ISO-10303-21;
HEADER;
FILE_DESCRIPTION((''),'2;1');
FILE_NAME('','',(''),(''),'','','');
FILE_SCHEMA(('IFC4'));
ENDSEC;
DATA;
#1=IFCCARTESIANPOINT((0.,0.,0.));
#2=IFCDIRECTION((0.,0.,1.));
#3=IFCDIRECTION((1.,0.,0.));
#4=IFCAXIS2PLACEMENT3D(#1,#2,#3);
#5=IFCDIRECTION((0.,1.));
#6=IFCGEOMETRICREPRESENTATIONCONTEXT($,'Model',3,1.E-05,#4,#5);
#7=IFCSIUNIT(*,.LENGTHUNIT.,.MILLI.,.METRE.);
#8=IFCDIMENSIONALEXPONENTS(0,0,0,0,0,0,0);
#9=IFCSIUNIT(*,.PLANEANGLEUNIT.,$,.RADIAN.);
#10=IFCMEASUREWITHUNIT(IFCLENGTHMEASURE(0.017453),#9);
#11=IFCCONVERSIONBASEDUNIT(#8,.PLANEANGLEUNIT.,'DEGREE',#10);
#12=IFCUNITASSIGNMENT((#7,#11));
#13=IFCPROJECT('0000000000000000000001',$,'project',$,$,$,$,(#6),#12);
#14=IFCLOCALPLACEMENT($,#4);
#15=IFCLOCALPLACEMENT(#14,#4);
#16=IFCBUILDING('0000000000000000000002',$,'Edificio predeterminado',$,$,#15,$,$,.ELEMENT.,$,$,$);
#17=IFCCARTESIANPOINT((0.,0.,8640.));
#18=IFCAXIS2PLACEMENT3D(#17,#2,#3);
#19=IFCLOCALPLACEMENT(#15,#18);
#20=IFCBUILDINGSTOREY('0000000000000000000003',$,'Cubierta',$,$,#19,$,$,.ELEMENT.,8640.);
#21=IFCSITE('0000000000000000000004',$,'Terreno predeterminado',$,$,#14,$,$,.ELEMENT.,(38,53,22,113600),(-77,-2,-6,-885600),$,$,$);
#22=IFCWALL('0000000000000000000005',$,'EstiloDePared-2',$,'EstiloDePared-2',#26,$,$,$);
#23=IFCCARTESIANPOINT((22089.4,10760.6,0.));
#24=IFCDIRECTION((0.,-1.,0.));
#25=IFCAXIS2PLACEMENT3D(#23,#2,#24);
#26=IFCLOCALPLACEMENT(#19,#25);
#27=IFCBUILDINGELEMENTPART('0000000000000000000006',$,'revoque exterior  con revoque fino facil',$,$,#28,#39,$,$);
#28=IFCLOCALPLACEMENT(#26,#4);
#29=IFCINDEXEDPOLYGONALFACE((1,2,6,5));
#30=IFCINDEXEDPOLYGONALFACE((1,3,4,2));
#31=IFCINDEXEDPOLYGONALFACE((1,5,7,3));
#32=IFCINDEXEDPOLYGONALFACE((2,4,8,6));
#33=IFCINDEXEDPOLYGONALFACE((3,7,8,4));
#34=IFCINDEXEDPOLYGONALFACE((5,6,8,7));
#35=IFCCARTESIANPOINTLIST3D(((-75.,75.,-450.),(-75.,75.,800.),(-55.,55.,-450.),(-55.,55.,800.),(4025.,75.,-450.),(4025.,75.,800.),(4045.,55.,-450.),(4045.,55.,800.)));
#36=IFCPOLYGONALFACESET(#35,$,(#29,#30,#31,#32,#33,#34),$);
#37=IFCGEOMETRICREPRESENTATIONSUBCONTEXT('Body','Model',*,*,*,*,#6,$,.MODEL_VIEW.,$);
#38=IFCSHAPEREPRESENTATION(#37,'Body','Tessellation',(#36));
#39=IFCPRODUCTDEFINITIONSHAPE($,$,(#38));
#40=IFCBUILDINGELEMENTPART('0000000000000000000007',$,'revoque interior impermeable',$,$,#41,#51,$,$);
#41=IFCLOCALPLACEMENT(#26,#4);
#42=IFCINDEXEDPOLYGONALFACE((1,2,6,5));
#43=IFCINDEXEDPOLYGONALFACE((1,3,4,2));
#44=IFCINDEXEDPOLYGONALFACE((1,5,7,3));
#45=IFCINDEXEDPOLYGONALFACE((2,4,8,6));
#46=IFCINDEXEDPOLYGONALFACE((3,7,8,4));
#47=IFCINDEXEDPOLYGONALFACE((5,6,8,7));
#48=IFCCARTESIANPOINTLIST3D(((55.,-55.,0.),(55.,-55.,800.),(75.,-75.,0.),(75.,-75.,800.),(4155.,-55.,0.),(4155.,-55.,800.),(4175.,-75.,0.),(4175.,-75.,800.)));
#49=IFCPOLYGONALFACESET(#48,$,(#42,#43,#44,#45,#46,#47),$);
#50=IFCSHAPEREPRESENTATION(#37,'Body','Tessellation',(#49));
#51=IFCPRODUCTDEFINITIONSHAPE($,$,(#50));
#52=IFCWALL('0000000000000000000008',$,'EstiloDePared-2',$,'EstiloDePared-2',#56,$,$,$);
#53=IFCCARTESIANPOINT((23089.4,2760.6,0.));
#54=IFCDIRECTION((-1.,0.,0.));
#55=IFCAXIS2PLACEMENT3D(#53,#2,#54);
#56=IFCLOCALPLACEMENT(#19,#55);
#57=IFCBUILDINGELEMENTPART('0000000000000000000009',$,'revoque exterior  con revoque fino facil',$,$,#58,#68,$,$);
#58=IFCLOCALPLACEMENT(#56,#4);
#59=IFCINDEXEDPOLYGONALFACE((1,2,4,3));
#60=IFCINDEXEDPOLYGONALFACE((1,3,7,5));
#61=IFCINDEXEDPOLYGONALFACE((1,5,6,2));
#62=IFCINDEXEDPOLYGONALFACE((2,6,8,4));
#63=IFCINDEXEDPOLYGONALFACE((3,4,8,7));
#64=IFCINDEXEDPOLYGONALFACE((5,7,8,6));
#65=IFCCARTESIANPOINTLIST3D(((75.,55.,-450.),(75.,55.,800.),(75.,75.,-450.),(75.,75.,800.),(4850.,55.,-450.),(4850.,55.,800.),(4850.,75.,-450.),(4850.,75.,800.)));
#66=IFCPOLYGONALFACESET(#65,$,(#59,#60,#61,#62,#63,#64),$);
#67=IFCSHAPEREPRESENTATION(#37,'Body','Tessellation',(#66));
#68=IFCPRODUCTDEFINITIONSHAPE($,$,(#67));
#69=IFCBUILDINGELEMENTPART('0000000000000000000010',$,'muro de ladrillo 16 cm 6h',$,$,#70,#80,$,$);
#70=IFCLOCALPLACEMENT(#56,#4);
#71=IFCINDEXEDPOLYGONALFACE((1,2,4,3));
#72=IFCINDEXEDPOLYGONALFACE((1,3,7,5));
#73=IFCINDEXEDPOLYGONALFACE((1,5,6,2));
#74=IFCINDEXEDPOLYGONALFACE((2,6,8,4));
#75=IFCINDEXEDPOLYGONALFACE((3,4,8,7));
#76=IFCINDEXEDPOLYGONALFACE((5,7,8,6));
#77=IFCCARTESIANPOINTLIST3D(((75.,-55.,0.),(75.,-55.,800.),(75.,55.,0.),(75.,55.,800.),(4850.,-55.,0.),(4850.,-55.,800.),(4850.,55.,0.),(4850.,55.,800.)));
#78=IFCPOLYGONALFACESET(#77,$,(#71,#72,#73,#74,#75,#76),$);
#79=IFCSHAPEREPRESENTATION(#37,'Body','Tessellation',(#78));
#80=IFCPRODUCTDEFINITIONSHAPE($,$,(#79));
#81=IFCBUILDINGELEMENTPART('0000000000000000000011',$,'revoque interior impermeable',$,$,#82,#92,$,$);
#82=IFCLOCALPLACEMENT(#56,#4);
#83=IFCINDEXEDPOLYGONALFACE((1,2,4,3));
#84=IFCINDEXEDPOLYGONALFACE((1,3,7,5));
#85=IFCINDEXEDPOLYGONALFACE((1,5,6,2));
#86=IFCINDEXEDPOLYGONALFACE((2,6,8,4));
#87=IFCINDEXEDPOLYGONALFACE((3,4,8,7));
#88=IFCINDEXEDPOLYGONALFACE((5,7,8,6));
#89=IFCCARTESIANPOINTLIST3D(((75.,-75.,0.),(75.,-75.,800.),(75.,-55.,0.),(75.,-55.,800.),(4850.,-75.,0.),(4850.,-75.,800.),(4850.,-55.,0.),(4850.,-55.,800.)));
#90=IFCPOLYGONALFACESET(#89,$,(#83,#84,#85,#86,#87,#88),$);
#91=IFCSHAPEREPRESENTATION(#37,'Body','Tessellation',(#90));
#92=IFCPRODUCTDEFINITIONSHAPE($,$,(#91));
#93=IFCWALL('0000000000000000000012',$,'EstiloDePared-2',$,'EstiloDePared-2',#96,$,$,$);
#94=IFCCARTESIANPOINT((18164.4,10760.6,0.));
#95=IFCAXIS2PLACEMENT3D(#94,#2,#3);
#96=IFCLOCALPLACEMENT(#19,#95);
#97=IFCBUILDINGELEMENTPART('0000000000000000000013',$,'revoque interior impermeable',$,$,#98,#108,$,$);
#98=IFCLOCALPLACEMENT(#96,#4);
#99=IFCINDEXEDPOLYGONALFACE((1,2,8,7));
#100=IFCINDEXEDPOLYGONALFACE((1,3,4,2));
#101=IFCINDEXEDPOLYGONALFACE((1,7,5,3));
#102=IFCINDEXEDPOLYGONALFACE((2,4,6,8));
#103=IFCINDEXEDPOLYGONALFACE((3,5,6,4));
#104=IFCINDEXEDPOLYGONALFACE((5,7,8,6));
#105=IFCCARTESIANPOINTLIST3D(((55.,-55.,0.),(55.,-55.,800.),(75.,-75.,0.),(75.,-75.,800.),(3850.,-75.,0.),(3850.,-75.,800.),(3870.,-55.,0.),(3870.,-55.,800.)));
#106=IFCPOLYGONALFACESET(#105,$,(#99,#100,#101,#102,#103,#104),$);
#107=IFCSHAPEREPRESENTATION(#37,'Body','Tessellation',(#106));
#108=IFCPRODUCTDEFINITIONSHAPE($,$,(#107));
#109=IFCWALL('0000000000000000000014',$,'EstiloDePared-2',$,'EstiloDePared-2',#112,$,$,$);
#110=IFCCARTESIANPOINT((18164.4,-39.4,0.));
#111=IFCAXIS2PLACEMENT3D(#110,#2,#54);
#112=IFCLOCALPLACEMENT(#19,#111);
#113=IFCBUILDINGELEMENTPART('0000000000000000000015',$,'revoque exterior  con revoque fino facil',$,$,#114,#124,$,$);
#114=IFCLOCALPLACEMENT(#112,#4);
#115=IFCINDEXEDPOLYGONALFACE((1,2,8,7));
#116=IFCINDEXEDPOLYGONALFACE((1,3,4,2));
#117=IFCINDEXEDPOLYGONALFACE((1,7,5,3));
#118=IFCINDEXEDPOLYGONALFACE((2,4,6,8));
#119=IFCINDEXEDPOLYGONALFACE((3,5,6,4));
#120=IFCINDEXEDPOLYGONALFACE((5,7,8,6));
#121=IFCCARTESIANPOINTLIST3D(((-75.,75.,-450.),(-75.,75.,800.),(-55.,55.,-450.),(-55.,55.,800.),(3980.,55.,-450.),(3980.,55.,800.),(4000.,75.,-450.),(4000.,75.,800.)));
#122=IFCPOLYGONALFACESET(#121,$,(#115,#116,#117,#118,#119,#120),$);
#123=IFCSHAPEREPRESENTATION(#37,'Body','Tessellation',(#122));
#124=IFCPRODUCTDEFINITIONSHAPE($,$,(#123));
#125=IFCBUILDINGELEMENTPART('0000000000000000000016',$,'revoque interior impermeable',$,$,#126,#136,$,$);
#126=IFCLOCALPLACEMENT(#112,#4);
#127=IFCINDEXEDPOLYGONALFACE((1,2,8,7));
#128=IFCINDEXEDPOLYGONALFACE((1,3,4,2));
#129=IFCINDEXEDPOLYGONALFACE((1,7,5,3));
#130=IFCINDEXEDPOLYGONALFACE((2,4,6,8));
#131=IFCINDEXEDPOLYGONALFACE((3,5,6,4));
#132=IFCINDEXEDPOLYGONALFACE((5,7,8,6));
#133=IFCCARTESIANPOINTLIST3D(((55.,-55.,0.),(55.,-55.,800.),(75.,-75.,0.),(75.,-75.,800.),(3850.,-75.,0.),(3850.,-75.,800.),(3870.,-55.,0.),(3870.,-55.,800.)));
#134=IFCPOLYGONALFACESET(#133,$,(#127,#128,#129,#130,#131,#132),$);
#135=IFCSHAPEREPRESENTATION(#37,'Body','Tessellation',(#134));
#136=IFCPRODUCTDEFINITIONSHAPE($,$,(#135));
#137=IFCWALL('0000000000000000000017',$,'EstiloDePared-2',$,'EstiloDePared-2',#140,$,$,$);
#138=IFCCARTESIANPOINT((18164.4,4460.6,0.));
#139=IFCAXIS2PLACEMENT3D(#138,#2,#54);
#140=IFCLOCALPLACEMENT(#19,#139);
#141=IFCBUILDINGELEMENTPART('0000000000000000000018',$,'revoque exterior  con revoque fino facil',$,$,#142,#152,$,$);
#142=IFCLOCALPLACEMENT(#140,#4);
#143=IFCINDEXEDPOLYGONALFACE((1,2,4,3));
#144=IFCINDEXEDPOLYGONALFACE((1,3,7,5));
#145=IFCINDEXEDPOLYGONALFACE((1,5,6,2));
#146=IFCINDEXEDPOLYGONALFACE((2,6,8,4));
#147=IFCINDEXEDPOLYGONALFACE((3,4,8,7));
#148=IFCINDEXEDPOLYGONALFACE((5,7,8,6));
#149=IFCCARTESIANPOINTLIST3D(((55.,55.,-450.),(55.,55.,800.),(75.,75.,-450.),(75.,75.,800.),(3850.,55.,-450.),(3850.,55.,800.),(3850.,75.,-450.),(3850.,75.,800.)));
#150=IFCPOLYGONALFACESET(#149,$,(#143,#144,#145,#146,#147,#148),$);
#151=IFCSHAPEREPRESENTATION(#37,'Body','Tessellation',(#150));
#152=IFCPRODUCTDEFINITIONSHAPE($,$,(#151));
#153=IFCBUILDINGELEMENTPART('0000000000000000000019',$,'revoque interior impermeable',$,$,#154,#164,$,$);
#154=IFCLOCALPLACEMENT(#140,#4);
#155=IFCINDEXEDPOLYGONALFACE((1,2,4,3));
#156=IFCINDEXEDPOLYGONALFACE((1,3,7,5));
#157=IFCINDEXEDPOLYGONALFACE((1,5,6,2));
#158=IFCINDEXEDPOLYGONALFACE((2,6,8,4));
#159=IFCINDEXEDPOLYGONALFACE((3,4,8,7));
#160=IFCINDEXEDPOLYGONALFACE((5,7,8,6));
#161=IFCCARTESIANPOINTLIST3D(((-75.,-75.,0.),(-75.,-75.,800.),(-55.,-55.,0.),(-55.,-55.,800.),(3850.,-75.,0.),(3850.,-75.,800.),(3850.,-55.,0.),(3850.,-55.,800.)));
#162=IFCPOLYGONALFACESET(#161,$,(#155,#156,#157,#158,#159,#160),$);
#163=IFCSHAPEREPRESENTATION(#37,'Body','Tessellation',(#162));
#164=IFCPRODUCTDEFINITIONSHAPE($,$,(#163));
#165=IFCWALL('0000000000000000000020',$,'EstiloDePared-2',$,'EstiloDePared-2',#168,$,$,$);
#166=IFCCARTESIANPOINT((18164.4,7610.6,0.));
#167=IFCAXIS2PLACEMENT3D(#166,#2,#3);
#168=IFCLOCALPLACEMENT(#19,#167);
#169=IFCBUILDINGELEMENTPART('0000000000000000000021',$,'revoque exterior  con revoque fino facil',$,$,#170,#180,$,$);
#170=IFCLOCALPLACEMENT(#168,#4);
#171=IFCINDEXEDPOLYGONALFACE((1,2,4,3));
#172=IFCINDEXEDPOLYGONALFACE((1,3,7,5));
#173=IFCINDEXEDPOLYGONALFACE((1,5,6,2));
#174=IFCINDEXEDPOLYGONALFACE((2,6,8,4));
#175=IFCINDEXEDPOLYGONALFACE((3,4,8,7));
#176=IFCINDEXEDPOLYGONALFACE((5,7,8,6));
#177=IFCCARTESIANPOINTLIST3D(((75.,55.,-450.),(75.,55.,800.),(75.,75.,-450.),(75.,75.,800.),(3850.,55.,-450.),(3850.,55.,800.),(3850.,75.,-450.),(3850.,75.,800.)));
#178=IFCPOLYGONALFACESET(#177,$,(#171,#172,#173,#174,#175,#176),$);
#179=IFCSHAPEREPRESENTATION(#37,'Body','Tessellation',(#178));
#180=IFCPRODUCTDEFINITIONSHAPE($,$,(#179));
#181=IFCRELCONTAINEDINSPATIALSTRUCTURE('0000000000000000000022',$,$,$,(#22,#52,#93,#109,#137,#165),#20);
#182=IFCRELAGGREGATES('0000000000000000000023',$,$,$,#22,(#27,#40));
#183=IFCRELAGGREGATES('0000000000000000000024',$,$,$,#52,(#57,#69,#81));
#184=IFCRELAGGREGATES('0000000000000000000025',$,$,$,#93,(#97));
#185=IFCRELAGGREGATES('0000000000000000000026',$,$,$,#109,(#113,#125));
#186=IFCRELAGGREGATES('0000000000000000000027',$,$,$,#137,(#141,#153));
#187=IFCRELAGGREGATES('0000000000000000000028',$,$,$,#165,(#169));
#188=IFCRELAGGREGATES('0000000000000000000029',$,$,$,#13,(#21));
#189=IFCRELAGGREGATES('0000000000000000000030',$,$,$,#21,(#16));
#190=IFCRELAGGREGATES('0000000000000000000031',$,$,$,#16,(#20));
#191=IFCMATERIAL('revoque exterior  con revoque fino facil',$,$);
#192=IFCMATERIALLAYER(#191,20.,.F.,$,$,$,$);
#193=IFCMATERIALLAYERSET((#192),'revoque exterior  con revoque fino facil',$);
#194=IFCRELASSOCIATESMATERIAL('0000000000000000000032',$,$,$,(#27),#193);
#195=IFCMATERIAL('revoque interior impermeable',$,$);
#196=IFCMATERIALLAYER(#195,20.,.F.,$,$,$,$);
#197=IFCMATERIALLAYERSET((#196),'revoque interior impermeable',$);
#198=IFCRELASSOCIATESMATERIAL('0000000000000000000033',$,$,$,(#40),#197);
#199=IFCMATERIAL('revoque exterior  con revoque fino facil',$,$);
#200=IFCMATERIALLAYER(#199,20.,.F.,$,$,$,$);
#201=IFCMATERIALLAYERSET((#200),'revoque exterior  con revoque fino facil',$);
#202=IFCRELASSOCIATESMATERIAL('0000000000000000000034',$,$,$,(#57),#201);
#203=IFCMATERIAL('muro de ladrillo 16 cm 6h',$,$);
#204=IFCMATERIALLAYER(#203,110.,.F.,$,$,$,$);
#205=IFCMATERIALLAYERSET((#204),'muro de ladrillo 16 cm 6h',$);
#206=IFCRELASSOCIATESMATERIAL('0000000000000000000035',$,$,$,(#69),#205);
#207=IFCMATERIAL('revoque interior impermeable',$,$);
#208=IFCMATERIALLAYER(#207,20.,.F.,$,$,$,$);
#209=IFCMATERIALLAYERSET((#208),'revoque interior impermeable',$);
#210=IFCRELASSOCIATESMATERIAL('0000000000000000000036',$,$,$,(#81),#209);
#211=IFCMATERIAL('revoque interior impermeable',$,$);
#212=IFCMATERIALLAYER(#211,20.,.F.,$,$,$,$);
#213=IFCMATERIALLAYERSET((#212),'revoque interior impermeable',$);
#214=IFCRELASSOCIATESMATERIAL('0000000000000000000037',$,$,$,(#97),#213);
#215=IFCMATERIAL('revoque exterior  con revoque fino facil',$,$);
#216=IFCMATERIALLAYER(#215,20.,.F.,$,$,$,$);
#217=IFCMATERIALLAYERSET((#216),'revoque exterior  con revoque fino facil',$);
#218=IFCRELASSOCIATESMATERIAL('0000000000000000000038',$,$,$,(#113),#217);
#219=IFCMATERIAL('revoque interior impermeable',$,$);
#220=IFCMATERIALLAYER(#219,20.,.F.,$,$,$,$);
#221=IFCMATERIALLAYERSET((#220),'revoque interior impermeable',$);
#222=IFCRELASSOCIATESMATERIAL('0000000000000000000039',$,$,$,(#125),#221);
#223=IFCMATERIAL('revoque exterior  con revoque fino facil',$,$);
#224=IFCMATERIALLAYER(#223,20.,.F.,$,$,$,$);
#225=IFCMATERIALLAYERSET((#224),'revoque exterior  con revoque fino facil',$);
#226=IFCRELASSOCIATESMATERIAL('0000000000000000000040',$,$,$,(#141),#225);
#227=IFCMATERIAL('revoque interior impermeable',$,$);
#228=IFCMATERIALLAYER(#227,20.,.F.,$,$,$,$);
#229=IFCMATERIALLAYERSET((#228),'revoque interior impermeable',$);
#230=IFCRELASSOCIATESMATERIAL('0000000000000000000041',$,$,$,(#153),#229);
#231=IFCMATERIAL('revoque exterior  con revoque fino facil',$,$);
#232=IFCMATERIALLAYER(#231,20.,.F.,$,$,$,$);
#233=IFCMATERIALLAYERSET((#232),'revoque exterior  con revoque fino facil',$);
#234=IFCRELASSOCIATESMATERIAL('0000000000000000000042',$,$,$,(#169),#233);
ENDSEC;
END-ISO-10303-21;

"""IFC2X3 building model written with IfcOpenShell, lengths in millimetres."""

from ifc_helpers import new_model, entity, si_unit, converted_unit, direction, frame, origin_with_axes, place, context, subcontext, project, spatial, polyline, outline, extrude, material, layer, layer_set, layer_usage, element, aggregate, save


model = new_model("IFC2X3")

# Units and contexts
model_context = context("Model", 3, precision=1e-05, world=origin_with_axes(), true_north=direction((0.0, 1.0)))
body_context = subcontext(model_context, "Body", "Model", "MODEL_VIEW")
ifc_project = project(units=[si_unit("LENGTHUNIT", "METRE", prefix="MILLI"), converted_unit("PLANEANGLEUNIT", "DEGREE", entity("IfcLengthMeasure", 0.017453), si_unit("PLANEANGLEUNIT", "RADIAN"), dimensions=[0, 0, 0, 0, 0, 0, 0])], contexts=[model_context])

# Site, building, storey
site_placement = place(None, origin_with_axes())
site = spatial("IfcSite", under=ifc_project, at=site_placement, Name="Terreno predeterminado", CompositionType="ELEMENT", RefLatitude=(38, 53, 22, 113600), RefLongitude=(-77, -2, -6, -885600))
building_placement = place(site_placement, origin_with_axes())
building = spatial("IfcBuilding", under=site, at=building_placement, Name="Edificio predeterminado", CompositionType="ELEMENT")
storey_placement = place(building_placement, frame((0.0, 0.0, 8640.0), z_axis=(0.0, 0.0, 1.0), x_axis=(1.0, 0.0, 0.0)))
storey = spatial("IfcBuildingStorey", under=building, at=storey_placement, Name="Cubierta", CompositionType="ELEMENT", Elevation=8640.0)

# Walls, building element parts
wall_1_placement = place(storey_placement, frame((22089.4, 10760.6, 0.0), z_axis=(0.0, 0.0, 1.0), x_axis=(0.0, -1.0, 0.0)))
wall_1 = element("IfcWall", 1, at=wall_1_placement, inside=storey, Name="EstiloDePared-2", ObjectType="EstiloDePared-2")
ifc_material_1 = material(Name="revoque exterior  con revoque fino facil")
ifc_layer_1 = layer(ifc_material_1, 20.0, ventilated=False)
ifc_layer_set_1 = layer_set([ifc_layer_1], Name="revoque exterior  con revoque fino facil")
ifc_layer_usage_1 = layer_usage(ifc_layer_set_1, "AXIS2", "NEGATIVE", -75.0)
building_element_part_1_placement = place(wall_1_placement, origin_with_axes())
building_element_part_1 = element("IfcBuildingElementPart", 2, at=building_element_part_1_placement, material=ifc_layer_usage_1, Name="revoque exterior  con revoque fino facil", context=body_context, shape_type="SweptSolid", body=[
    extrude(outline(polyline([(4025.0, 75.0), (4045.0, 55.0), (-55.0, 55.0), (-75.0, 75.0), (4025.0, 75.0)])), frame((0.0, 0.0, -450.0), z_axis=(0.0, 0.0, 1.0), x_axis=(1.0, 0.0, 0.0)), (0.0, 0.0, 1.0), 1250.0),
])
ifc_material_2 = material(Name="revoque interior impermeable")
ifc_layer_2 = layer(ifc_material_2, 20.0, ventilated=False)
ifc_layer_set_2 = layer_set([ifc_layer_2], Name="revoque interior impermeable")
ifc_layer_usage_2 = layer_usage(ifc_layer_set_2, "AXIS2", "NEGATIVE", 55.0)
building_element_part_2_placement = place(wall_1_placement, origin_with_axes())
building_element_part_2 = element("IfcBuildingElementPart", 3, at=building_element_part_2_placement, material=ifc_layer_usage_2, Name="revoque interior impermeable", context=body_context, shape_type="SweptSolid", body=[
    extrude(outline(polyline([(4155.0, -55.0), (4175.0, -75.0), (75.0, -75.0), (55.0, -55.0), (4155.0, -55.0)])), origin_with_axes(), (0.0, 0.0, 1.0), 800.0),
])
aggregate(wall_1, [building_element_part_1, building_element_part_2])
wall_2_placement = place(storey_placement, frame((23089.4, 2760.6, 0.0), z_axis=(0.0, 0.0, 1.0), x_axis=(-1.0, 0.0, 0.0)))
wall_2 = element("IfcWall", 4, at=wall_2_placement, inside=storey, Name="EstiloDePared-2", ObjectType="EstiloDePared-2")
ifc_material_3 = material(Name="revoque exterior  con revoque fino facil")
ifc_layer_3 = layer(ifc_material_3, 20.0, ventilated=False)
ifc_layer_set_3 = layer_set([ifc_layer_3], Name="revoque exterior  con revoque fino facil")
ifc_layer_usage_3 = layer_usage(ifc_layer_set_3, "AXIS2", "NEGATIVE", -75.0)
building_element_part_3_placement = place(wall_2_placement, origin_with_axes())
building_element_part_3 = element("IfcBuildingElementPart", 5, at=building_element_part_3_placement, material=ifc_layer_usage_3, Name="revoque exterior  con revoque fino facil", context=body_context, shape_type="SweptSolid", body=[
    extrude(outline(polyline([(4850.0, 75.0), (4850.0, 55.0), (75.0, 55.0), (75.0, 75.0), (4850.0, 75.0)])), frame((0.0, 0.0, -450.0), z_axis=(0.0, 0.0, 1.0), x_axis=(1.0, 0.0, 0.0)), (0.0, 0.0, 1.0), 1250.0),
])
ifc_material_4 = material(Name="muro de ladrillo 16 cm 6h")
ifc_layer_4 = layer(ifc_material_4, 110.0, ventilated=False)
ifc_layer_set_4 = layer_set([ifc_layer_4], Name="muro de ladrillo 16 cm 6h")
ifc_layer_usage_4 = layer_usage(ifc_layer_set_4, "AXIS2", "NEGATIVE", -55.0)
building_element_part_4_placement = place(wall_2_placement, origin_with_axes())
building_element_part_4 = element("IfcBuildingElementPart", 6, at=building_element_part_4_placement, material=ifc_layer_usage_4, Name="muro de ladrillo 16 cm 6h", context=body_context, shape_type="SweptSolid", body=[
    extrude(outline(polyline([(4850.0, 55.0), (4850.0, -55.0), (75.0, -55.0), (75.0, 55.0), (4850.0, 55.0)])), origin_with_axes(), (0.0, 0.0, 1.0), 800.0),
])
ifc_material_5 = material(Name="revoque interior impermeable")
ifc_layer_5 = layer(ifc_material_5, 20.0, ventilated=False)
ifc_layer_set_5 = layer_set([ifc_layer_5], Name="revoque interior impermeable")
ifc_layer_usage_5 = layer_usage(ifc_layer_set_5, "AXIS2", "NEGATIVE", 55.0)
building_element_part_5_placement = place(wall_2_placement, origin_with_axes())
building_element_part_5 = element("IfcBuildingElementPart", 7, at=building_element_part_5_placement, material=ifc_layer_usage_5, Name="revoque interior impermeable", context=body_context, shape_type="SweptSolid", body=[
    extrude(outline(polyline([(4850.0, -55.0), (4850.0, -75.0), (75.0, -75.0), (75.0, -55.0), (4850.0, -55.0)])), origin_with_axes(), (0.0, 0.0, 1.0), 800.0),
])
aggregate(wall_2, [building_element_part_3, building_element_part_4, building_element_part_5])

# Wall, building element part
wall_3_placement = place(storey_placement, frame((18164.4, 10760.6, 0.0), z_axis=(0.0, 0.0, 1.0), x_axis=(1.0, 0.0, 0.0)))
wall_3 = element("IfcWall", 8, at=wall_3_placement, inside=storey, Name="EstiloDePared-2", ObjectType="EstiloDePared-2")
ifc_material_6 = material(Name="revoque interior impermeable")
ifc_layer_6 = layer(ifc_material_6, 20.0, ventilated=False)
ifc_layer_set_6 = layer_set([ifc_layer_6], Name="revoque interior impermeable")
ifc_layer_usage_6 = layer_usage(ifc_layer_set_6, "AXIS2", "NEGATIVE", 55.0)
building_element_part_6_placement = place(wall_3_placement, origin_with_axes())
building_element_part_6 = element("IfcBuildingElementPart", 9, at=building_element_part_6_placement, material=ifc_layer_usage_6, Name="revoque interior impermeable", context=body_context, shape_type="SweptSolid", body=[
    extrude(outline(polyline([(3870.0, -55.0), (3850.0, -75.0), (75.0, -75.0), (55.0, -55.0), (3870.0, -55.0)])), origin_with_axes(), (0.0, 0.0, 1.0), 800.0),
])
aggregate(wall_3, [building_element_part_6])

# Walls, building element parts
wall_4_placement = place(storey_placement, frame((18164.4, -39.4, 0.0), z_axis=(0.0, 0.0, 1.0), x_axis=(-1.0, 0.0, 0.0)))
wall_4 = element("IfcWall", 10, at=wall_4_placement, inside=storey, Name="EstiloDePared-2", ObjectType="EstiloDePared-2")
ifc_material_7 = material(Name="revoque exterior  con revoque fino facil")
ifc_layer_7 = layer(ifc_material_7, 20.0, ventilated=False)
ifc_layer_set_7 = layer_set([ifc_layer_7], Name="revoque exterior  con revoque fino facil")
ifc_layer_usage_7 = layer_usage(ifc_layer_set_7, "AXIS2", "NEGATIVE", -75.0)
building_element_part_7_placement = place(wall_4_placement, origin_with_axes())
building_element_part_7 = element("IfcBuildingElementPart", 11, at=building_element_part_7_placement, material=ifc_layer_usage_7, Name="revoque exterior  con revoque fino facil", context=body_context, shape_type="SweptSolid", body=[
    extrude(outline(polyline([(4000.0, 75.0), (3980.0, 55.0), (-55.0, 55.0), (-75.0, 75.0), (4000.0, 75.0)])), frame((0.0, 0.0, -450.0), z_axis=(0.0, 0.0, 1.0), x_axis=(1.0, 0.0, 0.0)), (0.0, 0.0, 1.0), 1250.0),
])
ifc_material_8 = material(Name="revoque interior impermeable")
ifc_layer_8 = layer(ifc_material_8, 20.0, ventilated=False)
ifc_layer_set_8 = layer_set([ifc_layer_8], Name="revoque interior impermeable")
ifc_layer_usage_8 = layer_usage(ifc_layer_set_8, "AXIS2", "NEGATIVE", 55.0)
building_element_part_8_placement = place(wall_4_placement, origin_with_axes())
building_element_part_8 = element("IfcBuildingElementPart", 12, at=building_element_part_8_placement, material=ifc_layer_usage_8, Name="revoque interior impermeable", context=body_context, shape_type="SweptSolid", body=[
    extrude(outline(polyline([(3870.0, -55.0), (3850.0, -75.0), (75.0, -75.0), (55.0, -55.0), (3870.0, -55.0)])), origin_with_axes(), (0.0, 0.0, 1.0), 800.0),
])
aggregate(wall_4, [building_element_part_7, building_element_part_8])
wall_5_placement = place(storey_placement, frame((18164.4, 4460.6, 0.0), z_axis=(0.0, 0.0, 1.0), x_axis=(-1.0, 0.0, 0.0)))
wall_5 = element("IfcWall", 13, at=wall_5_placement, inside=storey, Name="EstiloDePared-2", ObjectType="EstiloDePared-2")
ifc_material_9 = material(Name="revoque exterior  con revoque fino facil")
ifc_layer_9 = layer(ifc_material_9, 20.0, ventilated=False)
ifc_layer_set_9 = layer_set([ifc_layer_9], Name="revoque exterior  con revoque fino facil")
ifc_layer_usage_9 = layer_usage(ifc_layer_set_9, "AXIS2", "NEGATIVE", -75.0)
building_element_part_9_placement = place(wall_5_placement, origin_with_axes())
building_element_part_9 = element("IfcBuildingElementPart", 14, at=building_element_part_9_placement, material=ifc_layer_usage_9, Name="revoque exterior  con revoque fino facil", context=body_context, shape_type="SweptSolid", body=[
    extrude(outline(polyline([(3850.0, 75.0), (3850.0, 55.0), (55.0, 55.0), (75.0, 75.0), (3850.0, 75.0)])), frame((0.0, 0.0, -450.0), z_axis=(0.0, 0.0, 1.0), x_axis=(1.0, 0.0, 0.0)), (0.0, 0.0, 1.0), 1250.0),
])
ifc_material_10 = material(Name="revoque interior impermeable")
ifc_layer_10 = layer(ifc_material_10, 20.0, ventilated=False)
ifc_layer_set_10 = layer_set([ifc_layer_10], Name="revoque interior impermeable")
ifc_layer_usage_10 = layer_usage(ifc_layer_set_10, "AXIS2", "NEGATIVE", 55.0)
building_element_part_10_placement = place(wall_5_placement, origin_with_axes())
building_element_part_10 = element("IfcBuildingElementPart", 15, at=building_element_part_10_placement, material=ifc_layer_usage_10, Name="revoque interior impermeable", context=body_context, shape_type="SweptSolid", body=[
    extrude(outline(polyline([(3850.0, -55.0), (3850.0, -75.0), (-75.0, -75.0), (-55.0, -55.0), (3850.0, -55.0)])), origin_with_axes(), (0.0, 0.0, 1.0), 800.0),
])
aggregate(wall_5, [building_element_part_9, building_element_part_10])
wall_6_placement = place(storey_placement, frame((18164.4, 7610.6, 0.0), z_axis=(0.0, 0.0, 1.0), x_axis=(1.0, 0.0, 0.0)))
wall_6 = element("IfcWall", 16, at=wall_6_placement, inside=storey, Name="EstiloDePared-2", ObjectType="EstiloDePared-2")
ifc_material_11 = material(Name="revoque exterior  con revoque fino facil")
ifc_layer_11 = layer(ifc_material_11, 20.0, ventilated=False)
ifc_layer_set_11 = layer_set([ifc_layer_11], Name="revoque exterior  con revoque fino facil")
ifc_layer_usage_11 = layer_usage(ifc_layer_set_11, "AXIS2", "NEGATIVE", -75.0)
building_element_part_11_placement = place(wall_6_placement, origin_with_axes())
building_element_part_11 = element("IfcBuildingElementPart", 17, at=building_element_part_11_placement, material=ifc_layer_usage_11, Name="revoque exterior  con revoque fino facil", context=body_context, shape_type="SweptSolid", body=[
    extrude(outline(polyline([(3850.0, 75.0), (3850.0, 55.0), (75.0, 55.0), (75.0, 75.0), (3850.0, 75.0)])), frame((0.0, 0.0, -450.0), z_axis=(0.0, 0.0, 1.0), x_axis=(1.0, 0.0, 0.0)), (0.0, 0.0, 1.0), 1250.0),
])
aggregate(wall_6, [building_element_part_11])

save(model, "model.ifc")
